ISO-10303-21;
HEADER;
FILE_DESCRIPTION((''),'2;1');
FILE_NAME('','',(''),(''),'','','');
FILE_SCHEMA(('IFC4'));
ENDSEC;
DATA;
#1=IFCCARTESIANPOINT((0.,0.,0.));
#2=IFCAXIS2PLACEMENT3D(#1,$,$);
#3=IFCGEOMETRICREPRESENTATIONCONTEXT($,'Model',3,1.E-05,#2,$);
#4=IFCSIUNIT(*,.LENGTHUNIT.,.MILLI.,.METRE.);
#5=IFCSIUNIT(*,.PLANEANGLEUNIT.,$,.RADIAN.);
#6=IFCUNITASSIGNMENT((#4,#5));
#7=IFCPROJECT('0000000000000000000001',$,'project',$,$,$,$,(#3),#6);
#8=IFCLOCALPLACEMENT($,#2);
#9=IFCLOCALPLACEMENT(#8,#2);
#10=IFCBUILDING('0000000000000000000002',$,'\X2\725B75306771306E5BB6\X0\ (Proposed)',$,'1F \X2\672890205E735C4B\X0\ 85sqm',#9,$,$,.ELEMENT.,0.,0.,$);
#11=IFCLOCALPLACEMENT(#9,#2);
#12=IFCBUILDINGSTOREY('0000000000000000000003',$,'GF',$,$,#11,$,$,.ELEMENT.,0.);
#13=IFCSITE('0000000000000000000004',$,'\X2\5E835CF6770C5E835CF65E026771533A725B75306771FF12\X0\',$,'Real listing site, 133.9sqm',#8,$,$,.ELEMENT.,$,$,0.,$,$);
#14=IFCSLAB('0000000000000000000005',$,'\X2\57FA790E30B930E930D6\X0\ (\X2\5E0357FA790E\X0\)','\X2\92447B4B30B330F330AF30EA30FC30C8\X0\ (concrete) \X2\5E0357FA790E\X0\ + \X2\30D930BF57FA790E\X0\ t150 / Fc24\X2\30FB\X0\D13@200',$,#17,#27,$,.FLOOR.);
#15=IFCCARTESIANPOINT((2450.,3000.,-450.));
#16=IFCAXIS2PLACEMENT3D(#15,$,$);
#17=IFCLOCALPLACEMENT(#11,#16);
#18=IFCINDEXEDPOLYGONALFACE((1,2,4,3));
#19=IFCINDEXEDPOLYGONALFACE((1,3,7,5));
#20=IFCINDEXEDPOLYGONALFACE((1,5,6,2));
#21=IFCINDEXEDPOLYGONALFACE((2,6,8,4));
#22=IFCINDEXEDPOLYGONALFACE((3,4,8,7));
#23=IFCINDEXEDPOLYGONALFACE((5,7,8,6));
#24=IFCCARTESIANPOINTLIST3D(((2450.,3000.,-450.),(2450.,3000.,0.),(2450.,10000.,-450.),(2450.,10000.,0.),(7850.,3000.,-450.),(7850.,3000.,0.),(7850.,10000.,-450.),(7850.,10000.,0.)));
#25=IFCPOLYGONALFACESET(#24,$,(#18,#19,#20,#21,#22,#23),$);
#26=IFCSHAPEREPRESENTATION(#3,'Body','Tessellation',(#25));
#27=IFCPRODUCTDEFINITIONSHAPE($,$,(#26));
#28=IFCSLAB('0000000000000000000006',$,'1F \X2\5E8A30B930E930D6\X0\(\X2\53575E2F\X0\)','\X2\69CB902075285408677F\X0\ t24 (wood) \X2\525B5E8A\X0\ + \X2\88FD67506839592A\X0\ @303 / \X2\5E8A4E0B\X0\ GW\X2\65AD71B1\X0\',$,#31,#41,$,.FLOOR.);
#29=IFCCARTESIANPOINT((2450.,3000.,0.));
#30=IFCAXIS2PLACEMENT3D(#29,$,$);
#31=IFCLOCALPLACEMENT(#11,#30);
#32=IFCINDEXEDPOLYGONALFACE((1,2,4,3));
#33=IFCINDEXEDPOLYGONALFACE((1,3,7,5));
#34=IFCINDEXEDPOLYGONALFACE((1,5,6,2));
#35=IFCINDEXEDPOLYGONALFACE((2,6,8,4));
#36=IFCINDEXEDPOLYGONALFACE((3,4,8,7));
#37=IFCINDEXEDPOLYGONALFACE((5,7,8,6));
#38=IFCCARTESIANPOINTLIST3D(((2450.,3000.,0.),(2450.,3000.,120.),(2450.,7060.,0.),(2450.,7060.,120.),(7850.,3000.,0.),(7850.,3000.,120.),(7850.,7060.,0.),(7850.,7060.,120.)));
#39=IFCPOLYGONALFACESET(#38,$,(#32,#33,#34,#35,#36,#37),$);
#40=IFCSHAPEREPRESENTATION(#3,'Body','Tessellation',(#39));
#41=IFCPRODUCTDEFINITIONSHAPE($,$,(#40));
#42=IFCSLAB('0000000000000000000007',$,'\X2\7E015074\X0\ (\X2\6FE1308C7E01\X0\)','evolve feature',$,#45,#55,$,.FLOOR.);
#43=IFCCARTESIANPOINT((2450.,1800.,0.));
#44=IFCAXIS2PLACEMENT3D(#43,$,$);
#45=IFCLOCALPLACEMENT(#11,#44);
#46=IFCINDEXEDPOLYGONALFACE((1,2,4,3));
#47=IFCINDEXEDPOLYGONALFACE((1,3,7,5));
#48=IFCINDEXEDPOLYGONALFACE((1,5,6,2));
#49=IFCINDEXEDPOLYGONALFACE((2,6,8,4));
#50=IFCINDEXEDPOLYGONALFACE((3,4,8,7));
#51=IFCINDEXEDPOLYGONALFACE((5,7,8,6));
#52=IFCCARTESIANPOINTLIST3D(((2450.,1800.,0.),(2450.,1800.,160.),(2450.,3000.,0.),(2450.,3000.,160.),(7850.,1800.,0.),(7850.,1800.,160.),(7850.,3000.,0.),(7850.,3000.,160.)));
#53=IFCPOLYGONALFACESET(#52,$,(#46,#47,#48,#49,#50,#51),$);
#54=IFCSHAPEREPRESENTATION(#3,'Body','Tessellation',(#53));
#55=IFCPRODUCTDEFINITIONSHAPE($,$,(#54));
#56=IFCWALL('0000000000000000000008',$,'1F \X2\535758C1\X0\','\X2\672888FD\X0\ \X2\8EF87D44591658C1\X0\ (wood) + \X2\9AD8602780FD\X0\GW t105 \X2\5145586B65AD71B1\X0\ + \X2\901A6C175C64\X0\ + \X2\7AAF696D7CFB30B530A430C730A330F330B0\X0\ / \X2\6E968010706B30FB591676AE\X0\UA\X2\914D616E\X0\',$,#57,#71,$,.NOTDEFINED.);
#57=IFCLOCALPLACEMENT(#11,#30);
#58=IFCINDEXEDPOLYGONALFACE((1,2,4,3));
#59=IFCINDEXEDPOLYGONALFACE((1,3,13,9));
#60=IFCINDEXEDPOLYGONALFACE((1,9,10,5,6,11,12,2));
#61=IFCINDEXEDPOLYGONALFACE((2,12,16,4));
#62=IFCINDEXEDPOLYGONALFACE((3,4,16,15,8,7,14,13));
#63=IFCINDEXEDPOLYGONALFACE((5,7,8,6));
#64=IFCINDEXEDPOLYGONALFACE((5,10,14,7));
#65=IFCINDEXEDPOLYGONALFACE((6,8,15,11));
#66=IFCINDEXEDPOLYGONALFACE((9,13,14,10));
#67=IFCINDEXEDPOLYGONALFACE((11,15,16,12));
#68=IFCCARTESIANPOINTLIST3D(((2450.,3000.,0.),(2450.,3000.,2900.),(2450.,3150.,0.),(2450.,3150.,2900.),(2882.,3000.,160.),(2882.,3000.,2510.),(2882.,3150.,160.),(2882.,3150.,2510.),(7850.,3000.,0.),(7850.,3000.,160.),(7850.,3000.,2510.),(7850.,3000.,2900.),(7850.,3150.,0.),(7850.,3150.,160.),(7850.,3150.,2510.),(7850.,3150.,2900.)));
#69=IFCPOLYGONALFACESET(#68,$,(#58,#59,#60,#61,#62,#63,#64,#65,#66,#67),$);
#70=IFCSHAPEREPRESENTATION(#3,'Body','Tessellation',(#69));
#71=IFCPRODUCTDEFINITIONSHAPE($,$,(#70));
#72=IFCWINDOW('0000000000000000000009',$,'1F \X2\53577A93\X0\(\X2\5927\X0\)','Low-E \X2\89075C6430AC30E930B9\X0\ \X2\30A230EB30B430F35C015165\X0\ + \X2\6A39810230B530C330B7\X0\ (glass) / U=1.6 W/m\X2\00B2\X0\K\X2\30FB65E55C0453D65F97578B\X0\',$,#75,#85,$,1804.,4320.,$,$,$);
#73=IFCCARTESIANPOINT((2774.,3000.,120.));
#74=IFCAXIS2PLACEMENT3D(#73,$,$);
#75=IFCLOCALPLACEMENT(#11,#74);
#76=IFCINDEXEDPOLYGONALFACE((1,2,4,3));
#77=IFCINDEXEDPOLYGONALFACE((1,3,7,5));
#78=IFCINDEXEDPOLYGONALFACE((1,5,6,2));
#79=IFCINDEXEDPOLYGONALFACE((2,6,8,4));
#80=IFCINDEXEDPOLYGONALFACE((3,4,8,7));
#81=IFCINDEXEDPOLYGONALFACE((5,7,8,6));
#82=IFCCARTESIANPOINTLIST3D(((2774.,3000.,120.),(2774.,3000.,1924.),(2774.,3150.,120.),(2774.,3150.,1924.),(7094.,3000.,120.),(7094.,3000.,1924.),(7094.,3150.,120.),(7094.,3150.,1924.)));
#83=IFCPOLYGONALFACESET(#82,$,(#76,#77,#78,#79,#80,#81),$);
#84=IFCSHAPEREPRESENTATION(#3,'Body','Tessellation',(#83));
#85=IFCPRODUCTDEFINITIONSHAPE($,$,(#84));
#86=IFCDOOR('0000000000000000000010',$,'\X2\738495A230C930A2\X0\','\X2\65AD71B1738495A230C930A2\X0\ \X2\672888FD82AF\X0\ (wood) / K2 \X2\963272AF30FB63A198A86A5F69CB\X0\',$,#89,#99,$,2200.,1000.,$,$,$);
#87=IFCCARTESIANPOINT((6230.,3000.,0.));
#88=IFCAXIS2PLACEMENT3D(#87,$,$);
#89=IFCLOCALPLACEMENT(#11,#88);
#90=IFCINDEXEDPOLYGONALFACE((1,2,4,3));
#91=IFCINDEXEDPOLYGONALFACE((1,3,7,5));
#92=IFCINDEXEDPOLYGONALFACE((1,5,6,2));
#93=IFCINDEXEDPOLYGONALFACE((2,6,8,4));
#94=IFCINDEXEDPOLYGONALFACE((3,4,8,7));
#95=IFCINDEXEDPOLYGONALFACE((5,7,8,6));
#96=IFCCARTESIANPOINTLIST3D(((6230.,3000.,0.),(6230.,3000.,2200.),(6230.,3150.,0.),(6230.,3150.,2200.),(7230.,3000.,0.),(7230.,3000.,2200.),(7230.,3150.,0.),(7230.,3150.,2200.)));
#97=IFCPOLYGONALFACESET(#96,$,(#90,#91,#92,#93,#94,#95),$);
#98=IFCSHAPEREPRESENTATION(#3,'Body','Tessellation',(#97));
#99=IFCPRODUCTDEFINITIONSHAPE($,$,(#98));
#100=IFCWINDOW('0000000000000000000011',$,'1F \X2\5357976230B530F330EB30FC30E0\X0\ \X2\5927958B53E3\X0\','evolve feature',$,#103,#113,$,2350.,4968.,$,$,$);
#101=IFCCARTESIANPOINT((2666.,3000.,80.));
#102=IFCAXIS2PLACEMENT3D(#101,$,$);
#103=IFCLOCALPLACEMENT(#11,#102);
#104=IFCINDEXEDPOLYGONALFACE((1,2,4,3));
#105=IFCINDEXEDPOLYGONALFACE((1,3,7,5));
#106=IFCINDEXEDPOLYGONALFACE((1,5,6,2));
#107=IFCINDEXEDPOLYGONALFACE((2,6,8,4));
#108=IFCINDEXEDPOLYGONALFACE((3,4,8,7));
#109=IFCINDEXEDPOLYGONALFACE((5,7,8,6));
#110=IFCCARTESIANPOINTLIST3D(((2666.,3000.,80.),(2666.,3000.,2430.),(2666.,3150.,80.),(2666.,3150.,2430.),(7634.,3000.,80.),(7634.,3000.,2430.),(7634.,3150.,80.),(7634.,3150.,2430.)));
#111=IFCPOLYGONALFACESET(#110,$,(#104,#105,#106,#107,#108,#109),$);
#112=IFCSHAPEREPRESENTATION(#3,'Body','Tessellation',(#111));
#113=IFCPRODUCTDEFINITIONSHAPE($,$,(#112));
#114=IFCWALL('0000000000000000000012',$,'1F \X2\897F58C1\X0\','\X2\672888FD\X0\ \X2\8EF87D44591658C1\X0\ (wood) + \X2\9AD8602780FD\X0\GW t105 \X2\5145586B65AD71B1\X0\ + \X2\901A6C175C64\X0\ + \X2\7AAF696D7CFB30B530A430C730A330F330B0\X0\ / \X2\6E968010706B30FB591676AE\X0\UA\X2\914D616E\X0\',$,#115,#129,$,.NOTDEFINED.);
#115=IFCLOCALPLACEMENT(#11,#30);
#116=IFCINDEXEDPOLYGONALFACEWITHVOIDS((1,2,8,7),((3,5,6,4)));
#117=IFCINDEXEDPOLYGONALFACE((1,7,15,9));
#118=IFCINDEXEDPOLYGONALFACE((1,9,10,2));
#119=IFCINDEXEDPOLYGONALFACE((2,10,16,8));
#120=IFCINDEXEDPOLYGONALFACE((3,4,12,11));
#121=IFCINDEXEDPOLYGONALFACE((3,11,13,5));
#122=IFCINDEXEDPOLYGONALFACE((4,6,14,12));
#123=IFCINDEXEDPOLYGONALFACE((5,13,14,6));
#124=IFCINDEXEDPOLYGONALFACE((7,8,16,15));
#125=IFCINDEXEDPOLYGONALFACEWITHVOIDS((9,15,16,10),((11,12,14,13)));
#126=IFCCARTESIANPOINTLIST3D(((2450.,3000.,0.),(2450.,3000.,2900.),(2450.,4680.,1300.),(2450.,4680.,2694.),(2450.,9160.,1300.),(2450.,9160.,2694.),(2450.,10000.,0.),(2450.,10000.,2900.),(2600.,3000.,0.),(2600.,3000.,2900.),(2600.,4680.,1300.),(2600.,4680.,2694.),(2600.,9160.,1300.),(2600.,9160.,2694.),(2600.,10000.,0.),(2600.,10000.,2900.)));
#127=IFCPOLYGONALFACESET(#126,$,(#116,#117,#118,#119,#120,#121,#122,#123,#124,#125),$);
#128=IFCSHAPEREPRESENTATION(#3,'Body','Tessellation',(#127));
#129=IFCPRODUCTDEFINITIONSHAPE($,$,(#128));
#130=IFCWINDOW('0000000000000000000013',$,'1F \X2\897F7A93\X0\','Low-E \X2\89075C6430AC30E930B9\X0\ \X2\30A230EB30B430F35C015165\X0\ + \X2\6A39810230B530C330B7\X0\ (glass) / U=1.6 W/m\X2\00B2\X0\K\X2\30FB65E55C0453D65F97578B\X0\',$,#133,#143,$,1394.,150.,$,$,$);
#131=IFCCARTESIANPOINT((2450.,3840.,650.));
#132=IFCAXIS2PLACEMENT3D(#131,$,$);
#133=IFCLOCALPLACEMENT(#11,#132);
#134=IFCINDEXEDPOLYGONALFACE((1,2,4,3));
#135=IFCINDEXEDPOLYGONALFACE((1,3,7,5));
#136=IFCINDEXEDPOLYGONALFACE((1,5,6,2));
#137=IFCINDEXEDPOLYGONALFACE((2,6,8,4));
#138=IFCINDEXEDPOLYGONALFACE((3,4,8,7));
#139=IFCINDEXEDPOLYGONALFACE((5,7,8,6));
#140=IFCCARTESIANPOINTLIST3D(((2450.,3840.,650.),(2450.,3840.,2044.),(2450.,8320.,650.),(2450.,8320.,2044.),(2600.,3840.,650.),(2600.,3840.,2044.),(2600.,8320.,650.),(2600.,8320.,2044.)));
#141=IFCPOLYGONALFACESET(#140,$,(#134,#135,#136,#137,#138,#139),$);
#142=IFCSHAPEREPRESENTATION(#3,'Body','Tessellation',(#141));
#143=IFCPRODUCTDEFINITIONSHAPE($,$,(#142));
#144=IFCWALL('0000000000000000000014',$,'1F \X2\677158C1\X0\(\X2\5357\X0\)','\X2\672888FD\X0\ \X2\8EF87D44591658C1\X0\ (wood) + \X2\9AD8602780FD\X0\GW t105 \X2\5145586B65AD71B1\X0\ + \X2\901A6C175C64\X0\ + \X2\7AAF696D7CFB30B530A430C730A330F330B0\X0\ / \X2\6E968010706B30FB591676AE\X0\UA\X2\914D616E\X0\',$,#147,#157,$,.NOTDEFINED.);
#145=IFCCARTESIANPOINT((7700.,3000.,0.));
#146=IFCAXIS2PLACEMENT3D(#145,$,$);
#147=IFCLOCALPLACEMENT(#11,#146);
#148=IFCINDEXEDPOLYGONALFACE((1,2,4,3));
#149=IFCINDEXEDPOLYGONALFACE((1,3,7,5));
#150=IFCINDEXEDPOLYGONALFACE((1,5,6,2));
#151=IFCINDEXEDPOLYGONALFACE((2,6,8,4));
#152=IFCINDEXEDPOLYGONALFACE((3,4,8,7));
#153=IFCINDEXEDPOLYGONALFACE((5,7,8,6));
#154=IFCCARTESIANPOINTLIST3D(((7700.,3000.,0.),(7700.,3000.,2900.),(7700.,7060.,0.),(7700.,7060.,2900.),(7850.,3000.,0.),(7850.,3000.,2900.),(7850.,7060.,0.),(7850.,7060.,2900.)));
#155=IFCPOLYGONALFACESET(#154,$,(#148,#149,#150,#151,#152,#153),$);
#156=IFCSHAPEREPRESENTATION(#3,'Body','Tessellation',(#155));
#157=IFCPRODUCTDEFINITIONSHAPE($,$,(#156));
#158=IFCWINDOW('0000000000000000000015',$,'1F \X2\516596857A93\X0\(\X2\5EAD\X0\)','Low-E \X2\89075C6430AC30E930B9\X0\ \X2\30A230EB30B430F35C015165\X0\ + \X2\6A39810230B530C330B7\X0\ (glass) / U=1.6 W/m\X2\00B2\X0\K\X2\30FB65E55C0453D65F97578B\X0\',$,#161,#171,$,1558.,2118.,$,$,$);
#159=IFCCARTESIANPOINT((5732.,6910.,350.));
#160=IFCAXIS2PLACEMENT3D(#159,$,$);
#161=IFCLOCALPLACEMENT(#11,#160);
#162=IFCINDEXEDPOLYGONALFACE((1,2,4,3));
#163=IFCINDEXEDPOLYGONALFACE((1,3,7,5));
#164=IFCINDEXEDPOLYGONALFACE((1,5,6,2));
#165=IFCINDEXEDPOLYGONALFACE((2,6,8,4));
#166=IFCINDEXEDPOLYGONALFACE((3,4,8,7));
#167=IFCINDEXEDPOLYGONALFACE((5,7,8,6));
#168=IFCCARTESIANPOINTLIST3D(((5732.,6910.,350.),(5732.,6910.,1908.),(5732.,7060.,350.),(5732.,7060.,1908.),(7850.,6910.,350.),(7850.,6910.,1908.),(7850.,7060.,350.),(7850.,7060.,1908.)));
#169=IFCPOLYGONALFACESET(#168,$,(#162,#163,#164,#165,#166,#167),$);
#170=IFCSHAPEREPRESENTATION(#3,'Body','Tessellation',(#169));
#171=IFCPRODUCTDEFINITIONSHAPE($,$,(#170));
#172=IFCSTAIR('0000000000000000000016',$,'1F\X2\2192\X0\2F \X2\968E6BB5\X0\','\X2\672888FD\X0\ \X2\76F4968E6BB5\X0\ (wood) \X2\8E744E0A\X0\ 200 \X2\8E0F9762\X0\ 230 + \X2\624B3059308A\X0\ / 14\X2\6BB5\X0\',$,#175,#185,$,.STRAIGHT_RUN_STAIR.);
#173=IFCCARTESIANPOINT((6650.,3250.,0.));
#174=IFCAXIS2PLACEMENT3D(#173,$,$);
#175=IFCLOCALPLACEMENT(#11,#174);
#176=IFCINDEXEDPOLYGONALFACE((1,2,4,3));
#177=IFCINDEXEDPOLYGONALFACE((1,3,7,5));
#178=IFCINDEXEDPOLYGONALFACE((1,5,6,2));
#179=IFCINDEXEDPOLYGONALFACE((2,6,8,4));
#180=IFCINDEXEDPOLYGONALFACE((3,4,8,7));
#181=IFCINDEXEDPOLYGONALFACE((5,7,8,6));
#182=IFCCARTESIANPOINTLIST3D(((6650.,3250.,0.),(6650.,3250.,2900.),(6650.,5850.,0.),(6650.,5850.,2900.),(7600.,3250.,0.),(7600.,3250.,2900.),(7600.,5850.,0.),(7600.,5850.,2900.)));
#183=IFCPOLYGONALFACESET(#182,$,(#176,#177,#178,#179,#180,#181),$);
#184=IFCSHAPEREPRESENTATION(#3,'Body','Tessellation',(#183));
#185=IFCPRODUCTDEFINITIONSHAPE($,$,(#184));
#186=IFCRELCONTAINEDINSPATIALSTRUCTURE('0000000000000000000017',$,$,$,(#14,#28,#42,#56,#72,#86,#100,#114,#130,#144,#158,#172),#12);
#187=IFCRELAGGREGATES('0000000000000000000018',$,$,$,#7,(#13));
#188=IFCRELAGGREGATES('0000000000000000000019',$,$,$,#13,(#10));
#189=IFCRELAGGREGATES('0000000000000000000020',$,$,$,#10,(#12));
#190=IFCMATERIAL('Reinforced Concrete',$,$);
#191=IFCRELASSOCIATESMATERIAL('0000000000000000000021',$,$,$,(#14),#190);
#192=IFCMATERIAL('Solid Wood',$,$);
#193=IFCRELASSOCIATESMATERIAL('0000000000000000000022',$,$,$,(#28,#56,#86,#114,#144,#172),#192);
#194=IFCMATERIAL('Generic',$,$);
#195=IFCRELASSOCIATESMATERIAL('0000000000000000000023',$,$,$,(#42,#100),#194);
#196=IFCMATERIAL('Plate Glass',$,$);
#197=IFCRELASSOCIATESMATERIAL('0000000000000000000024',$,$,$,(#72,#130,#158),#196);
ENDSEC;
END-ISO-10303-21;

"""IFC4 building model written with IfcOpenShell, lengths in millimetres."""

from ifc_helpers import new_model, si_unit, frame, frame_2d, origin, place, context, project, spatial, rectangle, extrude, material, element, fill, save


model = new_model("IFC4")

# Units and contexts
model_context = context("Model", 3, precision=1e-05, world=origin())
ifc_project = project(units=[si_unit("LENGTHUNIT", "METRE", prefix="MILLI"), si_unit("PLANEANGLEUNIT", "RADIAN")], contexts=[model_context])

# Site, building, storey
site_placement = place(None, origin())
site = spatial("IfcSite", under=ifc_project, at=site_placement, Name="広島県広島市東区牛田東２", ObjectType="Real listing site, 133.9sqm", CompositionType="ELEMENT", RefElevation=0.0)
building_placement = place(site_placement, origin())
building = spatial("IfcBuilding", under=site, at=building_placement, Name="牛田東の家 (Proposed)", ObjectType="1F 木造平屋 85sqm", CompositionType="ELEMENT", ElevationOfRefHeight=0.0, ElevationOfTerrain=0.0)
storey_placement = place(building_placement, origin())
storey = spatial("IfcBuildingStorey", under=building, at=storey_placement, Name="GF", CompositionType="ELEMENT", Elevation=0.0)

# Slabs
ifc_material_1 = material(Name="Reinforced Concrete")
slab_1_placement = place(storey_placement, frame((2450.0, 3000.0, -450.0)))
element("IfcSlab", 1, at=slab_1_placement, inside=storey, material=ifc_material_1, Name="基礎スラブ (布基礎)", Description="鉄筋コンクリート (concrete) 布基礎 + ベタ基礎 t150 / Fc24・D13@200", PredefinedType="FLOOR", context=model_context, shape_type="SweptSolid", body=[
    extrude(rectangle(XDim=5400.0, YDim=7000.0, at=frame_2d((2700.0, 3500.0))), frame((2450.0, 3000.0, -450.0)), (0.0, 0.0, 1.0), 450.0),
])
ifc_material_2 = material(Name="Solid Wood")
slab_2_placement = place(storey_placement, frame((2450.0, 3000.0, 0.0)))
element("IfcSlab", 2, at=slab_2_placement, inside=storey, material=ifc_material_2, Name="1F 床スラブ(南帯)", Description="構造用合板 t24 (wood) 剛床 + 製材根太 @303 / 床下 GW断熱", PredefinedType="FLOOR", context=model_context, shape_type="SweptSolid", body=[
    extrude(rectangle(XDim=5400.0, YDim=4060.0, at=frame_2d((2700.0, 2030.0))), frame((2450.0, 3000.0, 0.0)), (0.0, 0.0, 1.0), 120.0),
])
ifc_material_3 = material(Name="Generic")
slab_3_placement = place(storey_placement, frame((2450.0, 1800.0, 0.0)))
element("IfcSlab", 3, at=slab_3_placement, inside=storey, material=ifc_material_3, Name="縁側 (濡れ縁)", Description="evolve feature", PredefinedType="FLOOR", context=model_context, shape_type="SweptSolid", body=[
    extrude(rectangle(XDim=5400.0, YDim=1200.0, at=frame_2d((2700.0, 600.0))), frame((2450.0, 1800.0, 0.0)), (0.0, 0.0, 1.0), 160.0),
])

# Wall, openings, windows, door
wall_1_placement = place(storey_placement, frame((2450.0, 3000.0, 0.0)))
wall_1 = element("IfcWall", 4, at=wall_1_placement, inside=storey, material=ifc_material_2, Name="1F 南壁", Description="木製 軸組外壁 (wood) + 高性能GW t105 充填断熱 + 通気層 + 窯業系サイディング / 準耐火・外皮UA配慮", PredefinedType="NOTDEFINED", context=model_context, shape_type="SweptSolid", body=[
    extrude(rectangle(XDim=5400.0, YDim=150.0, at=frame_2d((2700.0, 75.0))), frame((2450.0, 3000.0, 0.0)), (0.0, 0.0, 1.0), 2900.0),
])
opening_1_placement = place(storey_placement, frame((2774.0, 3000.0, 120.0)))
opening_1 = element("IfcOpeningElement", 5, at=opening_1_placement, cuts=wall_1, PredefinedType="NOTDEFINED", context=model_context, shape_type="SweptSolid", body=[
    extrude(rectangle(XDim=4320.0, YDim=150.0, at=frame_2d((2160.0, 75.0))), frame((2774.0, 3000.0, 120.0)), (0.0, 0.0, 1.0), 1804.0),
])
opening_2_placement = place(storey_placement, frame((6230.0, 3000.0, 0.0)))
opening_2 = element("IfcOpeningElement", 6, at=opening_2_placement, cuts=wall_1, PredefinedType="NOTDEFINED", context=model_context, shape_type="SweptSolid", body=[
    extrude(rectangle(XDim=1000.0, YDim=150.0, at=frame_2d((500.0, 75.0))), frame((6230.0, 3000.0, 0.0)), (0.0, 0.0, 1.0), 2200.0),
])
opening_3_placement = place(storey_placement, frame((2666.0, 3000.0, 80.0)))
opening_3 = element("IfcOpeningElement", 7, at=opening_3_placement, cuts=wall_1, PredefinedType="NOTDEFINED", context=model_context, shape_type="SweptSolid", body=[
    extrude(rectangle(XDim=4968.0, YDim=150.0, at=frame_2d((2484.0, 75.0))), frame((2666.0, 3000.0, 80.0)), (0.0, 0.0, 1.0), 2350.0),
])
ifc_material_4 = material(Name="Plate Glass")
window_1_placement = place(storey_placement, frame((2774.0, 3000.0, 120.0)))
window_1 = element("IfcWindow", 8, at=window_1_placement, inside=storey, material=ifc_material_4, Name="1F 南窓(大)", Description="Low-E 複層ガラス アルゴン封入 + 樹脂サッシ (glass) / U=1.6 W/m²K・日射取得型", OverallHeight=1804.0, OverallWidth=4320.0, context=model_context, shape_type="SweptSolid", body=[
    extrude(rectangle(XDim=4320.0, YDim=150.0, at=frame_2d((2160.0, 75.0))), frame((2774.0, 3000.0, 120.0)), (0.0, 0.0, 1.0), 1804.0),
])
fill(opening_1, window_1)
door_1_placement = place(storey_placement, frame((6230.0, 3000.0, 0.0)))
door_1 = element("IfcDoor", 9, at=door_1_placement, inside=storey, material=ifc_material_2, Name="玄関ドア", Description="断熱玄関ドア 木製芯 (wood) / K2 防犯・採風機構", OverallHeight=2200.0, OverallWidth=1000.0, context=model_context, shape_type="SweptSolid", body=[
    extrude(rectangle(XDim=1000.0, YDim=150.0, at=frame_2d((500.0, 75.0))), frame((6230.0, 3000.0, 0.0)), (0.0, 0.0, 1.0), 2200.0),
])
fill(opening_2, door_1)
window_2_placement = place(storey_placement, frame((2666.0, 3000.0, 80.0)))
window_2 = element("IfcWindow", 10, at=window_2_placement, inside=storey, material=ifc_material_3, Name="1F 南面サンルーム 大開口", Description="evolve feature", OverallHeight=2350.0, OverallWidth=4968.0, context=model_context, shape_type="SweptSolid", body=[
    extrude(rectangle(XDim=4968.0, YDim=150.0, at=frame_2d((2484.0, 75.0))), frame((2666.0, 3000.0, 80.0)), (0.0, 0.0, 1.0), 2350.0),
])
fill(opening_3, window_2)

# Walls, openings, windows
wall_2_placement = place(storey_placement, frame((2450.0, 3000.0, 0.0)))
wall_2 = element("IfcWall", 11, at=wall_2_placement, inside=storey, material=ifc_material_2, Name="1F 西壁", Description="木製 軸組外壁 (wood) + 高性能GW t105 充填断熱 + 通気層 + 窯業系サイディング / 準耐火・外皮UA配慮", PredefinedType="NOTDEFINED", context=model_context, shape_type="SweptSolid", body=[
    extrude(rectangle(XDim=150.0, YDim=7000.0, at=frame_2d((75.0, 3500.0))), frame((2450.0, 3000.0, 0.0)), (0.0, 0.0, 1.0), 2900.0),
])
opening_4_placement = place(storey_placement, frame((2450.0, 3840.0, 650.0)))
opening_4 = element("IfcOpeningElement", 12, at=opening_4_placement, cuts=wall_2, PredefinedType="NOTDEFINED", context=model_context, shape_type="SweptSolid", body=[
    extrude(rectangle(XDim=150.0, YDim=4480.0, at=frame_2d((75.0, 2240.0))), frame((2450.0, 3840.0, 650.0)), (0.0, 0.0, 1.0), 1394.0),
])
window_3_placement = place(storey_placement, frame((2450.0, 3840.0, 650.0)))
window_3 = element("IfcWindow", 13, at=window_3_placement, inside=storey, material=ifc_material_4, Name="1F 西窓", Description="Low-E 複層ガラス アルゴン封入 + 樹脂サッシ (glass) / U=1.6 W/m²K・日射取得型", OverallHeight=1394.0, OverallWidth=150.0, context=model_context, shape_type="SweptSolid", body=[
    extrude(rectangle(XDim=150.0, YDim=4480.0, at=frame_2d((75.0, 2240.0))), frame((2450.0, 3840.0, 650.0)), (0.0, 0.0, 1.0), 1394.0),
])
fill(opening_4, window_3)
wall_3_placement = place(storey_placement, frame((7700.0, 3000.0, 0.0)))
wall_3 = element("IfcWall", 14, at=wall_3_placement, inside=storey, material=ifc_material_2, Name="1F 東壁(南)", Description="木製 軸組外壁 (wood) + 高性能GW t105 充填断熱 + 通気層 + 窯業系サイディング / 準耐火・外皮UA配慮", PredefinedType="NOTDEFINED", context=model_context, shape_type="SweptSolid", body=[
    extrude(rectangle(XDim=150.0, YDim=4060.0, at=frame_2d((75.0, 2030.0))), frame((7700.0, 3000.0, 0.0)), (0.0, 0.0, 1.0), 2900.0),
])
opening_5_placement = place(storey_placement, frame((5732.0, 6910.0, 350.0)))
opening_5 = element("IfcOpeningElement", 15, at=opening_5_placement, cuts=wall_3, PredefinedType="NOTDEFINED", context=model_context, shape_type="SweptSolid", body=[
    extrude(rectangle(XDim=2118.0, YDim=150.0, at=frame_2d((1059.0, 75.0))), frame((5732.0, 6910.0, 350.0)), (0.0, 0.0, 1.0), 1558.0),
])
window_4_placement = place(storey_placement, frame((5732.0, 6910.0, 350.0)))
window_4 = element("IfcWindow", 16, at=window_4_placement, inside=storey, material=ifc_material_4, Name="1F 入隅窓(庭)", Description="Low-E 複層ガラス アルゴン封入 + 樹脂サッシ (glass) / U=1.6 W/m²K・日射取得型", OverallHeight=1558.0, OverallWidth=2118.0, context=model_context, shape_type="SweptSolid", body=[
    extrude(rectangle(XDim=2118.0, YDim=150.0, at=frame_2d((1059.0, 75.0))), frame((5732.0, 6910.0, 350.0)), (0.0, 0.0, 1.0), 1558.0),
])
fill(opening_5, window_4)

# Stair
stair_placement = place(storey_placement, frame((6650.0, 3250.0, 0.0)))
element("IfcStair", 17, at=stair_placement, inside=storey, material=ifc_material_2, Name="1F→2F 階段", Description="木製 直階段 (wood) 蹴上 200 踏面 230 + 手すり / 14段", PredefinedType="STRAIGHT_RUN_STAIR", context=model_context, shape_type="SweptSolid", body=[
    extrude(rectangle(XDim=950.0, YDim=2600.0, at=frame_2d((475.0, 1300.0))), frame((6650.0, 3250.0, 0.0)), (0.0, 0.0, 1.0), 2900.0),
])

save(model, "model.ifc")
